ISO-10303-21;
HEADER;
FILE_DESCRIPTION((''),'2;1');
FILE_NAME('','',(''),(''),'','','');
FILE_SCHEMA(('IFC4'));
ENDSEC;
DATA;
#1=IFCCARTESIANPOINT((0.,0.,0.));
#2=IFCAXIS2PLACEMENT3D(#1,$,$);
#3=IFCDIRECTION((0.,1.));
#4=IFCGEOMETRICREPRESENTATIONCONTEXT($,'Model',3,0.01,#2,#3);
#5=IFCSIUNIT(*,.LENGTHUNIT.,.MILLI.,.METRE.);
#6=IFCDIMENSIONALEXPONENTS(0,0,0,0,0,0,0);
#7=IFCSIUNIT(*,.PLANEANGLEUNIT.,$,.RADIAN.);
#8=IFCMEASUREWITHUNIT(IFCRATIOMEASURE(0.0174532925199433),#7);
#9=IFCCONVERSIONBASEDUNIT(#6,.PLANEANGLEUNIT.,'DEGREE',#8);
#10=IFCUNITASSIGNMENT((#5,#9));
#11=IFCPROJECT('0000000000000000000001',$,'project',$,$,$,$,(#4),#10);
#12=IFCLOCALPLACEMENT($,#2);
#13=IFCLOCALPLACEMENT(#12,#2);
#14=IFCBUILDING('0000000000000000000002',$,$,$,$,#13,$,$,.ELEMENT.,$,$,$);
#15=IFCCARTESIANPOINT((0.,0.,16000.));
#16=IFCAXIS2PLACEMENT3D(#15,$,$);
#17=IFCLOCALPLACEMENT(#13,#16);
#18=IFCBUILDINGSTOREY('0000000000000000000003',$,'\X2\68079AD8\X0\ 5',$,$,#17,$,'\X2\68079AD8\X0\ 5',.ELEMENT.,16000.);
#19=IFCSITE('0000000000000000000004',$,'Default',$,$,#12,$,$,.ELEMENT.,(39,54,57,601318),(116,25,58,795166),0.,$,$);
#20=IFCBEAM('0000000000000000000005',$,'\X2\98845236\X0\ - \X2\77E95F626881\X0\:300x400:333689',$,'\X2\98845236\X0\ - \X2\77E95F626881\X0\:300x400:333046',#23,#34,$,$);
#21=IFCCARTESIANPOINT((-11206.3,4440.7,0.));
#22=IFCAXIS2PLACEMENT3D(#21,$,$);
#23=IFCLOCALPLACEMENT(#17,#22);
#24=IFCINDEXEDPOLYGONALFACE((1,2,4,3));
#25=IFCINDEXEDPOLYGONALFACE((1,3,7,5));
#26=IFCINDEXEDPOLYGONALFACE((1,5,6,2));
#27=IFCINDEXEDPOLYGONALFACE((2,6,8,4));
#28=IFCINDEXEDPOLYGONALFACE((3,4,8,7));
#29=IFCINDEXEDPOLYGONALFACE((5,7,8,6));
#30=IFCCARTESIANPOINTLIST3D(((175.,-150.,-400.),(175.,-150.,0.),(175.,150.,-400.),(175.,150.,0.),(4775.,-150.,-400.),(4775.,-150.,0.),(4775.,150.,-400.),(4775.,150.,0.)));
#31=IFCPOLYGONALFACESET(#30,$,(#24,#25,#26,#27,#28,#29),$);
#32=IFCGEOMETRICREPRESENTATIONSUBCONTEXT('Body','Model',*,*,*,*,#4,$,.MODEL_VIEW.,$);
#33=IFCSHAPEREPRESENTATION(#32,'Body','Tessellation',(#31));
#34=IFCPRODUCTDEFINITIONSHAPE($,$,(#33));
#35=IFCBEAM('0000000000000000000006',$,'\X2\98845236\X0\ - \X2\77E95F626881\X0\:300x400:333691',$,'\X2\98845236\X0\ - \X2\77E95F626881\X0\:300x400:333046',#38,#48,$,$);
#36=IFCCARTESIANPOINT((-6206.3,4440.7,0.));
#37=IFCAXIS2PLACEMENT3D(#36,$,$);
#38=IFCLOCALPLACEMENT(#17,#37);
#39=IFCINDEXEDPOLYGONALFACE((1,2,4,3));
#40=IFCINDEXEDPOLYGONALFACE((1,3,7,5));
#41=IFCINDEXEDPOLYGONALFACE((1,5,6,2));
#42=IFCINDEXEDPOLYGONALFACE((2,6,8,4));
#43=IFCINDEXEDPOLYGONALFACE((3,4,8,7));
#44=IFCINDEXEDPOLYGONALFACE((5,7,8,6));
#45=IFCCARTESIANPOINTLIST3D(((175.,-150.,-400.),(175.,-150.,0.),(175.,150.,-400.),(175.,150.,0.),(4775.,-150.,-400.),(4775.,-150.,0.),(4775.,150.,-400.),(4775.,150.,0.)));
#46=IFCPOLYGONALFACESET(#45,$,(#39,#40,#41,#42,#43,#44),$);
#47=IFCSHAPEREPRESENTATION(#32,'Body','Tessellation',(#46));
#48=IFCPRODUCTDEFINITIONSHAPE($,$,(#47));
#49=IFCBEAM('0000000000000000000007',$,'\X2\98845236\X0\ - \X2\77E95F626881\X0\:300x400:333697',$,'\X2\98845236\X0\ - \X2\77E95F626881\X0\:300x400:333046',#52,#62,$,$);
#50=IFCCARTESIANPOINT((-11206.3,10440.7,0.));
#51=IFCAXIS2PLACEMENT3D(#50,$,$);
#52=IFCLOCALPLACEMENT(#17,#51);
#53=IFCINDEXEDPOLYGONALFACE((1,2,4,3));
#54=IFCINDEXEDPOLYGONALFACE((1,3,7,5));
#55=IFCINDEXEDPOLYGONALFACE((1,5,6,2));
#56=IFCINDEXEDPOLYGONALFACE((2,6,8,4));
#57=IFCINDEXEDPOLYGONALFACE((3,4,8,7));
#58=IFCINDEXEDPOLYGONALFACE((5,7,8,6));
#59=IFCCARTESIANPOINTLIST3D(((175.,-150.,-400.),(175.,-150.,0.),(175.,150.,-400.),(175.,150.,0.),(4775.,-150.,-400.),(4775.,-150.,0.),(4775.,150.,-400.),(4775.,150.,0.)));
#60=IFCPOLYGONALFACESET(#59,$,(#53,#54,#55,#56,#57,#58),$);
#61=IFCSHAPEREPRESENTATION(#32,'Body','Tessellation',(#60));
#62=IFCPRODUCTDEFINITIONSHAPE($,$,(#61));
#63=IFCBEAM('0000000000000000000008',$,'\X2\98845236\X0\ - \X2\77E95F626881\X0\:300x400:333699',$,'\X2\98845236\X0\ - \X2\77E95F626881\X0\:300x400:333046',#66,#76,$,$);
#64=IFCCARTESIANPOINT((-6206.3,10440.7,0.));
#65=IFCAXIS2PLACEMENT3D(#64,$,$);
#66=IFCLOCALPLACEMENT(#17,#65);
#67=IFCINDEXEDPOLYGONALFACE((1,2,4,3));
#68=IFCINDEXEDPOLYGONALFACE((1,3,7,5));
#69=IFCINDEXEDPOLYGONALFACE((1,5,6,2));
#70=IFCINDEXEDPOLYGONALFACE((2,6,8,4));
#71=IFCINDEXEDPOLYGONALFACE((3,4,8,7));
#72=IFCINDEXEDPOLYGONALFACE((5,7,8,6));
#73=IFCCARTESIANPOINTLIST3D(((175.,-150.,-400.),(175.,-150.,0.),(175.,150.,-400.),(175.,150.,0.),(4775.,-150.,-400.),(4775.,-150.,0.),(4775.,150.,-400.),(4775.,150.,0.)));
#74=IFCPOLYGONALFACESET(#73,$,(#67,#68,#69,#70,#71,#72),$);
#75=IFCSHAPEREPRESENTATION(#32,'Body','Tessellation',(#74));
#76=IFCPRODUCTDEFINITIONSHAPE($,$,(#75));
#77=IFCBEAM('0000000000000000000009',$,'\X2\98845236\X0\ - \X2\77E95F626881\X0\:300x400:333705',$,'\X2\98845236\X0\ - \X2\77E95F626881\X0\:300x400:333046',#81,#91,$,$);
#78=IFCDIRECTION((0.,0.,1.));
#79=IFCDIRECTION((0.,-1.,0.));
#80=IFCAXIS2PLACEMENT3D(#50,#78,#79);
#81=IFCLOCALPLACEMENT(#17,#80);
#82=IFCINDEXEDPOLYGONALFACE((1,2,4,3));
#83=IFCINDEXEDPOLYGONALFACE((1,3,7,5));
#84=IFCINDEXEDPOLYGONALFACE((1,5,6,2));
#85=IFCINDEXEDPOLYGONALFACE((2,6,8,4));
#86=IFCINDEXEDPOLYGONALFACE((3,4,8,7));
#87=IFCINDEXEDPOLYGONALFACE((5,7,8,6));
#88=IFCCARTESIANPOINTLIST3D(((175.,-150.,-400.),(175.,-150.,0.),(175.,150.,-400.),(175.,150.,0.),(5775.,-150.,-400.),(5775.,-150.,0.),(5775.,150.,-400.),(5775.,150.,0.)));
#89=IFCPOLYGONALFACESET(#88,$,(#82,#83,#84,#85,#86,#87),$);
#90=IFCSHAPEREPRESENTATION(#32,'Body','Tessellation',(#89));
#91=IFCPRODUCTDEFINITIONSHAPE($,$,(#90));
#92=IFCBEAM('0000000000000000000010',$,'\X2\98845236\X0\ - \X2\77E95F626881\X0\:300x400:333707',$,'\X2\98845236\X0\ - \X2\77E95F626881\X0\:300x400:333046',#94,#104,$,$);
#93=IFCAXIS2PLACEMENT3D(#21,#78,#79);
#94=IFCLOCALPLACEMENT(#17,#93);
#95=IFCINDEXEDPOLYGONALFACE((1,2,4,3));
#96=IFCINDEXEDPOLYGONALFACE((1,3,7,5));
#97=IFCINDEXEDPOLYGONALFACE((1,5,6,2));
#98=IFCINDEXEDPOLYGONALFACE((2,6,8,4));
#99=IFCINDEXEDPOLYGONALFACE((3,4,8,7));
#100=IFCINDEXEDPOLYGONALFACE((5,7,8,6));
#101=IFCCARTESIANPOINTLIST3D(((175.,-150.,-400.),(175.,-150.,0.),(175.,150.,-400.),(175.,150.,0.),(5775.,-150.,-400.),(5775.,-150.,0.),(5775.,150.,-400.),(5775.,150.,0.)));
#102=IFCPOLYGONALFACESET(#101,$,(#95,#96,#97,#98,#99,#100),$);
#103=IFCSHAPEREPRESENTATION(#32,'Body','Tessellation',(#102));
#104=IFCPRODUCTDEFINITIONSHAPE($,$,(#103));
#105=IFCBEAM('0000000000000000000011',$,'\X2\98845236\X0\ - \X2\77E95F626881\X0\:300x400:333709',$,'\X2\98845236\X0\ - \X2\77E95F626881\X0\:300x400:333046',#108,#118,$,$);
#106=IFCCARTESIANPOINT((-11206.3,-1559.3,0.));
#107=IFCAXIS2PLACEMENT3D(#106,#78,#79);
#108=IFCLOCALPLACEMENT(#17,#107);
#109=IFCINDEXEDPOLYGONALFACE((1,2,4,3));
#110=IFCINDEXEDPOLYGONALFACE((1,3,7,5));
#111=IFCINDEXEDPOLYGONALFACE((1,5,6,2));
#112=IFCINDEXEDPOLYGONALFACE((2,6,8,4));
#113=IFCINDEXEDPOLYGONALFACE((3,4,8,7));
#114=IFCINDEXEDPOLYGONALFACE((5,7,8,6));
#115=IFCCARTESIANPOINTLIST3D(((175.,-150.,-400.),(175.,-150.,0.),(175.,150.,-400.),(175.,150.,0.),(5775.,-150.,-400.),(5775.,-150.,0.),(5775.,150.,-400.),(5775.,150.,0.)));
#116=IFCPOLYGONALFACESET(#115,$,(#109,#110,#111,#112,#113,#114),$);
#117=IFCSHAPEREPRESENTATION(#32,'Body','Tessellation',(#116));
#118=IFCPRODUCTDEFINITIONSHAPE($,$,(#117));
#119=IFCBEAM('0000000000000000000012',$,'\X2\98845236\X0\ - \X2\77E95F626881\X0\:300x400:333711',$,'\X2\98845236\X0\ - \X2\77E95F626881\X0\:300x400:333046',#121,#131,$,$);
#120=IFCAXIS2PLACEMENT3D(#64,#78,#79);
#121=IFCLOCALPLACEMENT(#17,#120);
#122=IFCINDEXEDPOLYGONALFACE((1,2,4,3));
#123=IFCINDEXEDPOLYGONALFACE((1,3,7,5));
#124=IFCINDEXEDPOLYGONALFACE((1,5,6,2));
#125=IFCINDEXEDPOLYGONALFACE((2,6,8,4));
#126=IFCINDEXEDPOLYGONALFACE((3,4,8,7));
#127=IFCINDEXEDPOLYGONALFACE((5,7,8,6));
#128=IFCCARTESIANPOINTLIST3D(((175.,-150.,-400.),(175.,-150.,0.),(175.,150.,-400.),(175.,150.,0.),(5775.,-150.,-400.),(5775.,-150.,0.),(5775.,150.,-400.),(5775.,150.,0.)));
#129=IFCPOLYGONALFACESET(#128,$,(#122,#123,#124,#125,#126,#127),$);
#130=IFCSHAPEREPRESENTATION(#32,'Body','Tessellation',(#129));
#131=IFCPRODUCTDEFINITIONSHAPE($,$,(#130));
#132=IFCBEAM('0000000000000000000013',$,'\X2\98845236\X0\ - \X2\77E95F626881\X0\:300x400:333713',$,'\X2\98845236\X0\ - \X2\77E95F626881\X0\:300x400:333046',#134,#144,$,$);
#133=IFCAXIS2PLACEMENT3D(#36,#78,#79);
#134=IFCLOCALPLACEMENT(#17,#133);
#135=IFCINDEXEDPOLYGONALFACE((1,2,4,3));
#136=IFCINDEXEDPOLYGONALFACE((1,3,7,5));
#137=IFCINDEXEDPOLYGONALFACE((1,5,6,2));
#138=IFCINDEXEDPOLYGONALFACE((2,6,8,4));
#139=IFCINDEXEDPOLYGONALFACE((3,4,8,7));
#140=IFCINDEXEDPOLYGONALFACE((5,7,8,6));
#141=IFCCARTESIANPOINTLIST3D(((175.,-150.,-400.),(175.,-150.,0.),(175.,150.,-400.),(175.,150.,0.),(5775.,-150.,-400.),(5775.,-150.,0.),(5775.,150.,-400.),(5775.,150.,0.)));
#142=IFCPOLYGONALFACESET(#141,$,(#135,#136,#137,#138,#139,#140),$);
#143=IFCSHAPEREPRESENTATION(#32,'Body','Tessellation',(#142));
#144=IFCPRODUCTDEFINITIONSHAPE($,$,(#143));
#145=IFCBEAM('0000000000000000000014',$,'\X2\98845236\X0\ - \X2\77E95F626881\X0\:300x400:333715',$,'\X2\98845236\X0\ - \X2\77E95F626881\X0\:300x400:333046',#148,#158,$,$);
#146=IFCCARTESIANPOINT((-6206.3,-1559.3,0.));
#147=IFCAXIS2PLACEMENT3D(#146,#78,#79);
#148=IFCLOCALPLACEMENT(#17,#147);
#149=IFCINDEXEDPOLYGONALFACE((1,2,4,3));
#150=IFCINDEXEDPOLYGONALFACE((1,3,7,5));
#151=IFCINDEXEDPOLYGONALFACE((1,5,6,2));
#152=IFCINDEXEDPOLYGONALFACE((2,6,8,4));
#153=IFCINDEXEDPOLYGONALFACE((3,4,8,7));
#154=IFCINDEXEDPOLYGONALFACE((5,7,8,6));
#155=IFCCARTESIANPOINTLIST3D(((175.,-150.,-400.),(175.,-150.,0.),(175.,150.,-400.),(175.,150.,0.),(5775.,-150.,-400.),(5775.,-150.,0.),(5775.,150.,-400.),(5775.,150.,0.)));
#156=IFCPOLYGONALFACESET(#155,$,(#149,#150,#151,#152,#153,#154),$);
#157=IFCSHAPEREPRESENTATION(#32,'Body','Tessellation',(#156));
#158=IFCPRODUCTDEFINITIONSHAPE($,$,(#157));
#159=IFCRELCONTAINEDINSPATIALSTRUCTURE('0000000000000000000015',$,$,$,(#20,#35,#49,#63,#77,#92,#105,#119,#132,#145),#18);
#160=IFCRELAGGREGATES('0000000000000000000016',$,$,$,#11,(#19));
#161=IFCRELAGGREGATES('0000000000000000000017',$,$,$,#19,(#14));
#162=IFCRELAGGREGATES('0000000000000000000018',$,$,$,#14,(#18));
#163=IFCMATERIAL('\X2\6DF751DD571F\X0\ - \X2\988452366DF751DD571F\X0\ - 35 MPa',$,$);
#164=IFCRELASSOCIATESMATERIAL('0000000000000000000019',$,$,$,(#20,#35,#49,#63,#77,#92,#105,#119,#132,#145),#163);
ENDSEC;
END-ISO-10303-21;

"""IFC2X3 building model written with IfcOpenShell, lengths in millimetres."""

from ifc_helpers import new_model, entity, si_unit, converted_unit, direction, frame, frame_2d, origin, origin_2d_with_axis, place, context, subcontext, project, spatial, rectangle, extrude, material, element, save


model = new_model("IFC2X3")

# Units and contexts
model_context = context("Model", 3, precision=0.01, world=origin(), true_north=direction((0.0, 1.0)))
body_context = subcontext(model_context, "Body", "Model", "MODEL_VIEW")
ifc_project = project(units=[si_unit("LENGTHUNIT", "METRE", prefix="MILLI"), converted_unit("PLANEANGLEUNIT", "DEGREE", entity("IfcRatioMeasure", 0.0174532925199433), si_unit("PLANEANGLEUNIT", "RADIAN"), dimensions=[0, 0, 0, 0, 0, 0, 0])], contexts=[model_context])

# Site, building, storey
site_placement = place(None, origin())
site = spatial("IfcSite", under=ifc_project, at=site_placement, Name="Default", CompositionType="ELEMENT", RefLatitude=(39, 54, 57, 601318), RefLongitude=(116, 25, 58, 795166), RefElevation=0.0)
building_placement = place(site_placement, origin())
building = spatial("IfcBuilding", under=site, at=building_placement, CompositionType="ELEMENT")
storey_placement = place(building_placement, frame((0.0, 0.0, 16000.0)))
storey = spatial("IfcBuildingStorey", under=building, at=storey_placement, Name="标高 5", LongName="标高 5", CompositionType="ELEMENT", Elevation=16000.0)

# Shared definitions
ifc_material = material(Name="混凝土 - 预制混凝土 - 35 MPa")

# Beams
beam_1_placement = place(storey_placement, frame((-11206.3, 4440.7, 0.0)))
element("IfcBeam", 1, at=beam_1_placement, inside=storey, material=ifc_material, Name="预制 - 矩形梁:300x400:333689", ObjectType="预制 - 矩形梁:300x400:333046", context=body_context, shape_type="SweptSolid", body=[
    extrude(rectangle(XDim=400.0, YDim=300.0, at=frame_2d((0.0, 0.0), x_axis=(1.0, 0.0))), frame((175.0, 0.0, -200.0), z_axis=(1.0, 0.0, 0.0), x_axis=(0.0, 0.0, -1.0)), (0.0, 0.0, 1.0), 4600.0),
])
beam_2_placement = place(storey_placement, frame((-6206.3, 4440.7, 0.0)))
element("IfcBeam", 2, at=beam_2_placement, inside=storey, material=ifc_material, Name="预制 - 矩形梁:300x400:333691", ObjectType="预制 - 矩形梁:300x400:333046", context=body_context, shape_type="SweptSolid", body=[
    extrude(rectangle(XDim=400.0, YDim=300.0, at=frame_2d((0.0, 0.0), x_axis=(1.0, 0.0))), frame((175.0, 0.0, -200.0), z_axis=(1.0, 0.0, 0.0), x_axis=(0.0, 0.0, -1.0)), (0.0, 0.0, 1.0), 4600.0),
])
beam_3_placement = place(storey_placement, frame((-11206.3, 10440.7, 0.0)))
element("IfcBeam", 3, at=beam_3_placement, inside=storey, material=ifc_material, Name="预制 - 矩形梁:300x400:333697", ObjectType="预制 - 矩形梁:300x400:333046", context=body_context, shape_type="SweptSolid", body=[
    extrude(rectangle(XDim=400.0, YDim=300.0, at=frame_2d((0.0, 0.0), x_axis=(1.0, 0.0))), frame((175.0, 0.0, -200.0), z_axis=(1.0, 0.0, 0.0), x_axis=(0.0, 0.0, -1.0)), (0.0, 0.0, 1.0), 4600.0),
])
beam_4_placement = place(storey_placement, frame((-6206.3, 10440.7, 0.0)))
element("IfcBeam", 4, at=beam_4_placement, inside=storey, material=ifc_material, Name="预制 - 矩形梁:300x400:333699", ObjectType="预制 - 矩形梁:300x400:333046", context=body_context, shape_type="SweptSolid", body=[
    extrude(rectangle(XDim=400.0, YDim=300.0, at=frame_2d((0.0, 0.0), x_axis=(1.0, 0.0))), frame((175.0, 0.0, -200.0), z_axis=(1.0, 0.0, 0.0), x_axis=(0.0, 0.0, -1.0)), (0.0, 0.0, 1.0), 4600.0),
])
for number, where, z_axis, x_axis, name in (
    (5, (-11206.3, 10440.7, 0.0), (0.0, 0.0, 1.0), (0.0, -1.0, 0.0), "预制 - 矩形梁:300x400:333705"),
    (6, (-11206.3, 4440.7, 0.0), (0.0, 0.0, 1.0), (0.0, -1.0, 0.0), "预制 - 矩形梁:300x400:333707"),
):
    element("IfcBeam", number, at=place(storey_placement, frame(where, z_axis=z_axis, x_axis=x_axis)), inside=storey, material=ifc_material, Name=name, ObjectType="预制 - 矩形梁:300x400:333046", context=body_context, shape_type="SweptSolid", body=[
        extrude(rectangle(XDim=400.0, YDim=300.0, at=origin_2d_with_axis()), frame((175.0, 0.0, -200.0), z_axis=(1.0, 0.0, 0.0), x_axis=(0.0, 0.0, -1.0)), (0.0, 0.0, 1.0), 5600.0),
    ])
beam_5_placement = place(storey_placement, frame((-11206.3, -1559.3, 0.0), z_axis=(0.0, 0.0, 1.0), x_axis=(0.0, -1.0, 0.0)))
element("IfcBeam", 7, at=beam_5_placement, inside=storey, material=ifc_material, Name="预制 - 矩形梁:300x400:333709", ObjectType="预制 - 矩形梁:300x400:333046", context=body_context, shape_type="SweptSolid", body=[
    extrude(rectangle(XDim=400.0, YDim=300.0, at=frame_2d((0.0, 0.0), x_axis=(1.0, 0.0))), frame((175.0, 0.0, -200.0), z_axis=(1.0, 0.0, 0.0), x_axis=(0.0, 0.0, -1.0)), (0.0, 0.0, 1.0), 5600.0),
])
for number, where, z_axis, x_axis, name in (
    (8, (-6206.3, 10440.7, 0.0), (0.0, 0.0, 1.0), (0.0, -1.0, 0.0), "预制 - 矩形梁:300x400:333711"),
    (9, (-6206.3, 4440.7, 0.0), (0.0, 0.0, 1.0), (0.0, -1.0, 0.0), "预制 - 矩形梁:300x400:333713"),
    (10, (-6206.3, -1559.3, 0.0), (0.0, 0.0, 1.0), (0.0, -1.0, 0.0), "预制 - 矩形梁:300x400:333715"),
):
    element("IfcBeam", number, at=place(storey_placement, frame(where, z_axis=z_axis, x_axis=x_axis)), inside=storey, material=ifc_material, Name=name, ObjectType="预制 - 矩形梁:300x400:333046", context=body_context, shape_type="SweptSolid", body=[
        extrude(rectangle(XDim=400.0, YDim=300.0, at=origin_2d_with_axis()), frame((175.0, 0.0, -200.0), z_axis=(1.0, 0.0, 0.0), x_axis=(0.0, 0.0, -1.0)), (0.0, 0.0, 1.0), 5600.0),
    ])

save(model, "model.ifc")
